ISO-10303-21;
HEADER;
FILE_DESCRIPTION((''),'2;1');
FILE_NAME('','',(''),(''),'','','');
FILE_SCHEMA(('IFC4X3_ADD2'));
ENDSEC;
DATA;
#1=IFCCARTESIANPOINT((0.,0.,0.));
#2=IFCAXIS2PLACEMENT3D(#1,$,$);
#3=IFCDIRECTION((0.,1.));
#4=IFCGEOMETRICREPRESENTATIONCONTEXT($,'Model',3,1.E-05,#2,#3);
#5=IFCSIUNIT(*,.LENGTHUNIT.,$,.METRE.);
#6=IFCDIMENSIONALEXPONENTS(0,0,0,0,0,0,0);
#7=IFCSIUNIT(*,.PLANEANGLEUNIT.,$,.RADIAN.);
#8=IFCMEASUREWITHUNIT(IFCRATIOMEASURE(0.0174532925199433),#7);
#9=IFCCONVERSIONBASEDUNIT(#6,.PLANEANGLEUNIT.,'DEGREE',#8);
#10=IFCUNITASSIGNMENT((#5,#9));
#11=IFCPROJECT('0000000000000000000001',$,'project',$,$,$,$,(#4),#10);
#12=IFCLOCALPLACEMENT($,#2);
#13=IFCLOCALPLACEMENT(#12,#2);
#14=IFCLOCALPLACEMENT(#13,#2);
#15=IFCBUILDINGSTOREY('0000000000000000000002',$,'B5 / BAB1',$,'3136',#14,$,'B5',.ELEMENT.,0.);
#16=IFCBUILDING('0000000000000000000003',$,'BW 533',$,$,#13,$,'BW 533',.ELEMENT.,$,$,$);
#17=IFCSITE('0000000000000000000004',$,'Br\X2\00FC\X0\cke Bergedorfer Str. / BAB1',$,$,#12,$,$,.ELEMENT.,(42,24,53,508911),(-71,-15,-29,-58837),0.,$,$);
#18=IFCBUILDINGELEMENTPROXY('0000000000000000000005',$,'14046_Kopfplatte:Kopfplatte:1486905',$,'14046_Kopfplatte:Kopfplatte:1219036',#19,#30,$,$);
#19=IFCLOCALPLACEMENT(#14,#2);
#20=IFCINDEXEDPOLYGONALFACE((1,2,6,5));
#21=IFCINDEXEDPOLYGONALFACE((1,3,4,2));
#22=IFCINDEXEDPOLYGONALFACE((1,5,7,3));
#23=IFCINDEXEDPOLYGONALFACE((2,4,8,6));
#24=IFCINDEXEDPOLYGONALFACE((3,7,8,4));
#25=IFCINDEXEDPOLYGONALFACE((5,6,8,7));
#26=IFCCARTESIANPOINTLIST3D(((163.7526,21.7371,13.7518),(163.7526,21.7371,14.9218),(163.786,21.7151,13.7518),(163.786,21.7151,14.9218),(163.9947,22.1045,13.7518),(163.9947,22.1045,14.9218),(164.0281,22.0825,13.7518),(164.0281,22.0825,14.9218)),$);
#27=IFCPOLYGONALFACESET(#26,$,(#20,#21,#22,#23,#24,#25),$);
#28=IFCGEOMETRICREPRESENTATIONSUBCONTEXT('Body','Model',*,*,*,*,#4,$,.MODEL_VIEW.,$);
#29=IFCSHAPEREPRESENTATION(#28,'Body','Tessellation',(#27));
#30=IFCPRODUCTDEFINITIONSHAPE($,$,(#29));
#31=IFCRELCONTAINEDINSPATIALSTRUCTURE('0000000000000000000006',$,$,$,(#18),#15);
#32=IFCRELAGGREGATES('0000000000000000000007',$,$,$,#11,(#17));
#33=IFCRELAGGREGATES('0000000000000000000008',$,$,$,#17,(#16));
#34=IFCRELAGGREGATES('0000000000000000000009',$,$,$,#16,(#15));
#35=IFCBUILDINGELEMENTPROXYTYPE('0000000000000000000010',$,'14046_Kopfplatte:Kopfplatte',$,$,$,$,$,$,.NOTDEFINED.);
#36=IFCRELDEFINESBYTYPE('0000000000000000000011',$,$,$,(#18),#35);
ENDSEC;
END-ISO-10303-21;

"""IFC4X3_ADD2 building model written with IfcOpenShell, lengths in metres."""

from ifc_helpers import new_model, entity, si_unit, converted_unit, direction, frame, frame_2d, origin, place, context, subcontext, project, spatial, rectangle, extrude, source, transform, mapped, type_object, type_shapes, element, save


model = new_model("IFC4X3_ADD2")

# Units and contexts
model_context = context("Model", 3, precision=1e-05, world=origin(), true_north=direction((0.0, 1.0)))
body_context = subcontext(model_context, "Body", "Model", "MODEL_VIEW")
ifc_project = project(units=[si_unit("LENGTHUNIT", "METRE"), converted_unit("PLANEANGLEUNIT", "DEGREE", entity("IfcRatioMeasure", 0.0174532925199433), si_unit("PLANEANGLEUNIT", "RADIAN"), dimensions=[0, 0, 0, 0, 0, 0, 0])], contexts=[model_context])

# Site, building, storey
site_placement = place(None, origin())
site = spatial("IfcSite", under=ifc_project, at=site_placement, Name="Brücke Bergedorfer Str. / BAB1", CompositionType="ELEMENT", RefLatitude=(42, 24, 53, 508911), RefLongitude=(-71, -15, -29, -58837), RefElevation=0.0)
building_placement = place(site_placement, origin())
building = spatial("IfcBuilding", under=site, at=building_placement, Name="BW 533", LongName="BW 533", CompositionType="ELEMENT")
storey_placement = place(building_placement, origin())
storey = spatial("IfcBuildingStorey", under=building, at=storey_placement, Name="B5 / BAB1", ObjectType="3136", LongName="B5", CompositionType="ELEMENT", Elevation=0.0)

# Building element proxy
building_element_proxy_type_1 = type_object("IfcBuildingElementProxyType", Name="14046_Kopfplatte:Kopfplatte", PredefinedType="NOTDEFINED")
shared_shape_1 = source(origin(), body_context, "Body", "SweptSolid", [
    extrude(rectangle(XDim=0.04, YDim=0.44, at=frame_2d((0.0, 0.0), x_axis=(1.0, 0.0))), frame((163.8904, 21.9098, 13.7518), z_axis=(0.0, 0.0, 1.0), x_axis=(-0.835088, 0.550116, 0.0)), (0.0, 0.0, 1.0), 1.17),
])
type_shapes(building_element_proxy_type_1, [shared_shape_1])
proxy_1_placement = place(storey_placement, origin())
element("IfcBuildingElementProxy", 1, at=proxy_1_placement, inside=storey, type_object=building_element_proxy_type_1, Name="14046_Kopfplatte:Kopfplatte:1486905", ObjectType="14046_Kopfplatte:Kopfplatte:1219036", context=body_context, shape_type="MappedRepresentation", body=[
    mapped(shared_shape_1, transform((0.0, 0.0, 0.0), scale=1.0)),
])

save(model, "model.ifc")
